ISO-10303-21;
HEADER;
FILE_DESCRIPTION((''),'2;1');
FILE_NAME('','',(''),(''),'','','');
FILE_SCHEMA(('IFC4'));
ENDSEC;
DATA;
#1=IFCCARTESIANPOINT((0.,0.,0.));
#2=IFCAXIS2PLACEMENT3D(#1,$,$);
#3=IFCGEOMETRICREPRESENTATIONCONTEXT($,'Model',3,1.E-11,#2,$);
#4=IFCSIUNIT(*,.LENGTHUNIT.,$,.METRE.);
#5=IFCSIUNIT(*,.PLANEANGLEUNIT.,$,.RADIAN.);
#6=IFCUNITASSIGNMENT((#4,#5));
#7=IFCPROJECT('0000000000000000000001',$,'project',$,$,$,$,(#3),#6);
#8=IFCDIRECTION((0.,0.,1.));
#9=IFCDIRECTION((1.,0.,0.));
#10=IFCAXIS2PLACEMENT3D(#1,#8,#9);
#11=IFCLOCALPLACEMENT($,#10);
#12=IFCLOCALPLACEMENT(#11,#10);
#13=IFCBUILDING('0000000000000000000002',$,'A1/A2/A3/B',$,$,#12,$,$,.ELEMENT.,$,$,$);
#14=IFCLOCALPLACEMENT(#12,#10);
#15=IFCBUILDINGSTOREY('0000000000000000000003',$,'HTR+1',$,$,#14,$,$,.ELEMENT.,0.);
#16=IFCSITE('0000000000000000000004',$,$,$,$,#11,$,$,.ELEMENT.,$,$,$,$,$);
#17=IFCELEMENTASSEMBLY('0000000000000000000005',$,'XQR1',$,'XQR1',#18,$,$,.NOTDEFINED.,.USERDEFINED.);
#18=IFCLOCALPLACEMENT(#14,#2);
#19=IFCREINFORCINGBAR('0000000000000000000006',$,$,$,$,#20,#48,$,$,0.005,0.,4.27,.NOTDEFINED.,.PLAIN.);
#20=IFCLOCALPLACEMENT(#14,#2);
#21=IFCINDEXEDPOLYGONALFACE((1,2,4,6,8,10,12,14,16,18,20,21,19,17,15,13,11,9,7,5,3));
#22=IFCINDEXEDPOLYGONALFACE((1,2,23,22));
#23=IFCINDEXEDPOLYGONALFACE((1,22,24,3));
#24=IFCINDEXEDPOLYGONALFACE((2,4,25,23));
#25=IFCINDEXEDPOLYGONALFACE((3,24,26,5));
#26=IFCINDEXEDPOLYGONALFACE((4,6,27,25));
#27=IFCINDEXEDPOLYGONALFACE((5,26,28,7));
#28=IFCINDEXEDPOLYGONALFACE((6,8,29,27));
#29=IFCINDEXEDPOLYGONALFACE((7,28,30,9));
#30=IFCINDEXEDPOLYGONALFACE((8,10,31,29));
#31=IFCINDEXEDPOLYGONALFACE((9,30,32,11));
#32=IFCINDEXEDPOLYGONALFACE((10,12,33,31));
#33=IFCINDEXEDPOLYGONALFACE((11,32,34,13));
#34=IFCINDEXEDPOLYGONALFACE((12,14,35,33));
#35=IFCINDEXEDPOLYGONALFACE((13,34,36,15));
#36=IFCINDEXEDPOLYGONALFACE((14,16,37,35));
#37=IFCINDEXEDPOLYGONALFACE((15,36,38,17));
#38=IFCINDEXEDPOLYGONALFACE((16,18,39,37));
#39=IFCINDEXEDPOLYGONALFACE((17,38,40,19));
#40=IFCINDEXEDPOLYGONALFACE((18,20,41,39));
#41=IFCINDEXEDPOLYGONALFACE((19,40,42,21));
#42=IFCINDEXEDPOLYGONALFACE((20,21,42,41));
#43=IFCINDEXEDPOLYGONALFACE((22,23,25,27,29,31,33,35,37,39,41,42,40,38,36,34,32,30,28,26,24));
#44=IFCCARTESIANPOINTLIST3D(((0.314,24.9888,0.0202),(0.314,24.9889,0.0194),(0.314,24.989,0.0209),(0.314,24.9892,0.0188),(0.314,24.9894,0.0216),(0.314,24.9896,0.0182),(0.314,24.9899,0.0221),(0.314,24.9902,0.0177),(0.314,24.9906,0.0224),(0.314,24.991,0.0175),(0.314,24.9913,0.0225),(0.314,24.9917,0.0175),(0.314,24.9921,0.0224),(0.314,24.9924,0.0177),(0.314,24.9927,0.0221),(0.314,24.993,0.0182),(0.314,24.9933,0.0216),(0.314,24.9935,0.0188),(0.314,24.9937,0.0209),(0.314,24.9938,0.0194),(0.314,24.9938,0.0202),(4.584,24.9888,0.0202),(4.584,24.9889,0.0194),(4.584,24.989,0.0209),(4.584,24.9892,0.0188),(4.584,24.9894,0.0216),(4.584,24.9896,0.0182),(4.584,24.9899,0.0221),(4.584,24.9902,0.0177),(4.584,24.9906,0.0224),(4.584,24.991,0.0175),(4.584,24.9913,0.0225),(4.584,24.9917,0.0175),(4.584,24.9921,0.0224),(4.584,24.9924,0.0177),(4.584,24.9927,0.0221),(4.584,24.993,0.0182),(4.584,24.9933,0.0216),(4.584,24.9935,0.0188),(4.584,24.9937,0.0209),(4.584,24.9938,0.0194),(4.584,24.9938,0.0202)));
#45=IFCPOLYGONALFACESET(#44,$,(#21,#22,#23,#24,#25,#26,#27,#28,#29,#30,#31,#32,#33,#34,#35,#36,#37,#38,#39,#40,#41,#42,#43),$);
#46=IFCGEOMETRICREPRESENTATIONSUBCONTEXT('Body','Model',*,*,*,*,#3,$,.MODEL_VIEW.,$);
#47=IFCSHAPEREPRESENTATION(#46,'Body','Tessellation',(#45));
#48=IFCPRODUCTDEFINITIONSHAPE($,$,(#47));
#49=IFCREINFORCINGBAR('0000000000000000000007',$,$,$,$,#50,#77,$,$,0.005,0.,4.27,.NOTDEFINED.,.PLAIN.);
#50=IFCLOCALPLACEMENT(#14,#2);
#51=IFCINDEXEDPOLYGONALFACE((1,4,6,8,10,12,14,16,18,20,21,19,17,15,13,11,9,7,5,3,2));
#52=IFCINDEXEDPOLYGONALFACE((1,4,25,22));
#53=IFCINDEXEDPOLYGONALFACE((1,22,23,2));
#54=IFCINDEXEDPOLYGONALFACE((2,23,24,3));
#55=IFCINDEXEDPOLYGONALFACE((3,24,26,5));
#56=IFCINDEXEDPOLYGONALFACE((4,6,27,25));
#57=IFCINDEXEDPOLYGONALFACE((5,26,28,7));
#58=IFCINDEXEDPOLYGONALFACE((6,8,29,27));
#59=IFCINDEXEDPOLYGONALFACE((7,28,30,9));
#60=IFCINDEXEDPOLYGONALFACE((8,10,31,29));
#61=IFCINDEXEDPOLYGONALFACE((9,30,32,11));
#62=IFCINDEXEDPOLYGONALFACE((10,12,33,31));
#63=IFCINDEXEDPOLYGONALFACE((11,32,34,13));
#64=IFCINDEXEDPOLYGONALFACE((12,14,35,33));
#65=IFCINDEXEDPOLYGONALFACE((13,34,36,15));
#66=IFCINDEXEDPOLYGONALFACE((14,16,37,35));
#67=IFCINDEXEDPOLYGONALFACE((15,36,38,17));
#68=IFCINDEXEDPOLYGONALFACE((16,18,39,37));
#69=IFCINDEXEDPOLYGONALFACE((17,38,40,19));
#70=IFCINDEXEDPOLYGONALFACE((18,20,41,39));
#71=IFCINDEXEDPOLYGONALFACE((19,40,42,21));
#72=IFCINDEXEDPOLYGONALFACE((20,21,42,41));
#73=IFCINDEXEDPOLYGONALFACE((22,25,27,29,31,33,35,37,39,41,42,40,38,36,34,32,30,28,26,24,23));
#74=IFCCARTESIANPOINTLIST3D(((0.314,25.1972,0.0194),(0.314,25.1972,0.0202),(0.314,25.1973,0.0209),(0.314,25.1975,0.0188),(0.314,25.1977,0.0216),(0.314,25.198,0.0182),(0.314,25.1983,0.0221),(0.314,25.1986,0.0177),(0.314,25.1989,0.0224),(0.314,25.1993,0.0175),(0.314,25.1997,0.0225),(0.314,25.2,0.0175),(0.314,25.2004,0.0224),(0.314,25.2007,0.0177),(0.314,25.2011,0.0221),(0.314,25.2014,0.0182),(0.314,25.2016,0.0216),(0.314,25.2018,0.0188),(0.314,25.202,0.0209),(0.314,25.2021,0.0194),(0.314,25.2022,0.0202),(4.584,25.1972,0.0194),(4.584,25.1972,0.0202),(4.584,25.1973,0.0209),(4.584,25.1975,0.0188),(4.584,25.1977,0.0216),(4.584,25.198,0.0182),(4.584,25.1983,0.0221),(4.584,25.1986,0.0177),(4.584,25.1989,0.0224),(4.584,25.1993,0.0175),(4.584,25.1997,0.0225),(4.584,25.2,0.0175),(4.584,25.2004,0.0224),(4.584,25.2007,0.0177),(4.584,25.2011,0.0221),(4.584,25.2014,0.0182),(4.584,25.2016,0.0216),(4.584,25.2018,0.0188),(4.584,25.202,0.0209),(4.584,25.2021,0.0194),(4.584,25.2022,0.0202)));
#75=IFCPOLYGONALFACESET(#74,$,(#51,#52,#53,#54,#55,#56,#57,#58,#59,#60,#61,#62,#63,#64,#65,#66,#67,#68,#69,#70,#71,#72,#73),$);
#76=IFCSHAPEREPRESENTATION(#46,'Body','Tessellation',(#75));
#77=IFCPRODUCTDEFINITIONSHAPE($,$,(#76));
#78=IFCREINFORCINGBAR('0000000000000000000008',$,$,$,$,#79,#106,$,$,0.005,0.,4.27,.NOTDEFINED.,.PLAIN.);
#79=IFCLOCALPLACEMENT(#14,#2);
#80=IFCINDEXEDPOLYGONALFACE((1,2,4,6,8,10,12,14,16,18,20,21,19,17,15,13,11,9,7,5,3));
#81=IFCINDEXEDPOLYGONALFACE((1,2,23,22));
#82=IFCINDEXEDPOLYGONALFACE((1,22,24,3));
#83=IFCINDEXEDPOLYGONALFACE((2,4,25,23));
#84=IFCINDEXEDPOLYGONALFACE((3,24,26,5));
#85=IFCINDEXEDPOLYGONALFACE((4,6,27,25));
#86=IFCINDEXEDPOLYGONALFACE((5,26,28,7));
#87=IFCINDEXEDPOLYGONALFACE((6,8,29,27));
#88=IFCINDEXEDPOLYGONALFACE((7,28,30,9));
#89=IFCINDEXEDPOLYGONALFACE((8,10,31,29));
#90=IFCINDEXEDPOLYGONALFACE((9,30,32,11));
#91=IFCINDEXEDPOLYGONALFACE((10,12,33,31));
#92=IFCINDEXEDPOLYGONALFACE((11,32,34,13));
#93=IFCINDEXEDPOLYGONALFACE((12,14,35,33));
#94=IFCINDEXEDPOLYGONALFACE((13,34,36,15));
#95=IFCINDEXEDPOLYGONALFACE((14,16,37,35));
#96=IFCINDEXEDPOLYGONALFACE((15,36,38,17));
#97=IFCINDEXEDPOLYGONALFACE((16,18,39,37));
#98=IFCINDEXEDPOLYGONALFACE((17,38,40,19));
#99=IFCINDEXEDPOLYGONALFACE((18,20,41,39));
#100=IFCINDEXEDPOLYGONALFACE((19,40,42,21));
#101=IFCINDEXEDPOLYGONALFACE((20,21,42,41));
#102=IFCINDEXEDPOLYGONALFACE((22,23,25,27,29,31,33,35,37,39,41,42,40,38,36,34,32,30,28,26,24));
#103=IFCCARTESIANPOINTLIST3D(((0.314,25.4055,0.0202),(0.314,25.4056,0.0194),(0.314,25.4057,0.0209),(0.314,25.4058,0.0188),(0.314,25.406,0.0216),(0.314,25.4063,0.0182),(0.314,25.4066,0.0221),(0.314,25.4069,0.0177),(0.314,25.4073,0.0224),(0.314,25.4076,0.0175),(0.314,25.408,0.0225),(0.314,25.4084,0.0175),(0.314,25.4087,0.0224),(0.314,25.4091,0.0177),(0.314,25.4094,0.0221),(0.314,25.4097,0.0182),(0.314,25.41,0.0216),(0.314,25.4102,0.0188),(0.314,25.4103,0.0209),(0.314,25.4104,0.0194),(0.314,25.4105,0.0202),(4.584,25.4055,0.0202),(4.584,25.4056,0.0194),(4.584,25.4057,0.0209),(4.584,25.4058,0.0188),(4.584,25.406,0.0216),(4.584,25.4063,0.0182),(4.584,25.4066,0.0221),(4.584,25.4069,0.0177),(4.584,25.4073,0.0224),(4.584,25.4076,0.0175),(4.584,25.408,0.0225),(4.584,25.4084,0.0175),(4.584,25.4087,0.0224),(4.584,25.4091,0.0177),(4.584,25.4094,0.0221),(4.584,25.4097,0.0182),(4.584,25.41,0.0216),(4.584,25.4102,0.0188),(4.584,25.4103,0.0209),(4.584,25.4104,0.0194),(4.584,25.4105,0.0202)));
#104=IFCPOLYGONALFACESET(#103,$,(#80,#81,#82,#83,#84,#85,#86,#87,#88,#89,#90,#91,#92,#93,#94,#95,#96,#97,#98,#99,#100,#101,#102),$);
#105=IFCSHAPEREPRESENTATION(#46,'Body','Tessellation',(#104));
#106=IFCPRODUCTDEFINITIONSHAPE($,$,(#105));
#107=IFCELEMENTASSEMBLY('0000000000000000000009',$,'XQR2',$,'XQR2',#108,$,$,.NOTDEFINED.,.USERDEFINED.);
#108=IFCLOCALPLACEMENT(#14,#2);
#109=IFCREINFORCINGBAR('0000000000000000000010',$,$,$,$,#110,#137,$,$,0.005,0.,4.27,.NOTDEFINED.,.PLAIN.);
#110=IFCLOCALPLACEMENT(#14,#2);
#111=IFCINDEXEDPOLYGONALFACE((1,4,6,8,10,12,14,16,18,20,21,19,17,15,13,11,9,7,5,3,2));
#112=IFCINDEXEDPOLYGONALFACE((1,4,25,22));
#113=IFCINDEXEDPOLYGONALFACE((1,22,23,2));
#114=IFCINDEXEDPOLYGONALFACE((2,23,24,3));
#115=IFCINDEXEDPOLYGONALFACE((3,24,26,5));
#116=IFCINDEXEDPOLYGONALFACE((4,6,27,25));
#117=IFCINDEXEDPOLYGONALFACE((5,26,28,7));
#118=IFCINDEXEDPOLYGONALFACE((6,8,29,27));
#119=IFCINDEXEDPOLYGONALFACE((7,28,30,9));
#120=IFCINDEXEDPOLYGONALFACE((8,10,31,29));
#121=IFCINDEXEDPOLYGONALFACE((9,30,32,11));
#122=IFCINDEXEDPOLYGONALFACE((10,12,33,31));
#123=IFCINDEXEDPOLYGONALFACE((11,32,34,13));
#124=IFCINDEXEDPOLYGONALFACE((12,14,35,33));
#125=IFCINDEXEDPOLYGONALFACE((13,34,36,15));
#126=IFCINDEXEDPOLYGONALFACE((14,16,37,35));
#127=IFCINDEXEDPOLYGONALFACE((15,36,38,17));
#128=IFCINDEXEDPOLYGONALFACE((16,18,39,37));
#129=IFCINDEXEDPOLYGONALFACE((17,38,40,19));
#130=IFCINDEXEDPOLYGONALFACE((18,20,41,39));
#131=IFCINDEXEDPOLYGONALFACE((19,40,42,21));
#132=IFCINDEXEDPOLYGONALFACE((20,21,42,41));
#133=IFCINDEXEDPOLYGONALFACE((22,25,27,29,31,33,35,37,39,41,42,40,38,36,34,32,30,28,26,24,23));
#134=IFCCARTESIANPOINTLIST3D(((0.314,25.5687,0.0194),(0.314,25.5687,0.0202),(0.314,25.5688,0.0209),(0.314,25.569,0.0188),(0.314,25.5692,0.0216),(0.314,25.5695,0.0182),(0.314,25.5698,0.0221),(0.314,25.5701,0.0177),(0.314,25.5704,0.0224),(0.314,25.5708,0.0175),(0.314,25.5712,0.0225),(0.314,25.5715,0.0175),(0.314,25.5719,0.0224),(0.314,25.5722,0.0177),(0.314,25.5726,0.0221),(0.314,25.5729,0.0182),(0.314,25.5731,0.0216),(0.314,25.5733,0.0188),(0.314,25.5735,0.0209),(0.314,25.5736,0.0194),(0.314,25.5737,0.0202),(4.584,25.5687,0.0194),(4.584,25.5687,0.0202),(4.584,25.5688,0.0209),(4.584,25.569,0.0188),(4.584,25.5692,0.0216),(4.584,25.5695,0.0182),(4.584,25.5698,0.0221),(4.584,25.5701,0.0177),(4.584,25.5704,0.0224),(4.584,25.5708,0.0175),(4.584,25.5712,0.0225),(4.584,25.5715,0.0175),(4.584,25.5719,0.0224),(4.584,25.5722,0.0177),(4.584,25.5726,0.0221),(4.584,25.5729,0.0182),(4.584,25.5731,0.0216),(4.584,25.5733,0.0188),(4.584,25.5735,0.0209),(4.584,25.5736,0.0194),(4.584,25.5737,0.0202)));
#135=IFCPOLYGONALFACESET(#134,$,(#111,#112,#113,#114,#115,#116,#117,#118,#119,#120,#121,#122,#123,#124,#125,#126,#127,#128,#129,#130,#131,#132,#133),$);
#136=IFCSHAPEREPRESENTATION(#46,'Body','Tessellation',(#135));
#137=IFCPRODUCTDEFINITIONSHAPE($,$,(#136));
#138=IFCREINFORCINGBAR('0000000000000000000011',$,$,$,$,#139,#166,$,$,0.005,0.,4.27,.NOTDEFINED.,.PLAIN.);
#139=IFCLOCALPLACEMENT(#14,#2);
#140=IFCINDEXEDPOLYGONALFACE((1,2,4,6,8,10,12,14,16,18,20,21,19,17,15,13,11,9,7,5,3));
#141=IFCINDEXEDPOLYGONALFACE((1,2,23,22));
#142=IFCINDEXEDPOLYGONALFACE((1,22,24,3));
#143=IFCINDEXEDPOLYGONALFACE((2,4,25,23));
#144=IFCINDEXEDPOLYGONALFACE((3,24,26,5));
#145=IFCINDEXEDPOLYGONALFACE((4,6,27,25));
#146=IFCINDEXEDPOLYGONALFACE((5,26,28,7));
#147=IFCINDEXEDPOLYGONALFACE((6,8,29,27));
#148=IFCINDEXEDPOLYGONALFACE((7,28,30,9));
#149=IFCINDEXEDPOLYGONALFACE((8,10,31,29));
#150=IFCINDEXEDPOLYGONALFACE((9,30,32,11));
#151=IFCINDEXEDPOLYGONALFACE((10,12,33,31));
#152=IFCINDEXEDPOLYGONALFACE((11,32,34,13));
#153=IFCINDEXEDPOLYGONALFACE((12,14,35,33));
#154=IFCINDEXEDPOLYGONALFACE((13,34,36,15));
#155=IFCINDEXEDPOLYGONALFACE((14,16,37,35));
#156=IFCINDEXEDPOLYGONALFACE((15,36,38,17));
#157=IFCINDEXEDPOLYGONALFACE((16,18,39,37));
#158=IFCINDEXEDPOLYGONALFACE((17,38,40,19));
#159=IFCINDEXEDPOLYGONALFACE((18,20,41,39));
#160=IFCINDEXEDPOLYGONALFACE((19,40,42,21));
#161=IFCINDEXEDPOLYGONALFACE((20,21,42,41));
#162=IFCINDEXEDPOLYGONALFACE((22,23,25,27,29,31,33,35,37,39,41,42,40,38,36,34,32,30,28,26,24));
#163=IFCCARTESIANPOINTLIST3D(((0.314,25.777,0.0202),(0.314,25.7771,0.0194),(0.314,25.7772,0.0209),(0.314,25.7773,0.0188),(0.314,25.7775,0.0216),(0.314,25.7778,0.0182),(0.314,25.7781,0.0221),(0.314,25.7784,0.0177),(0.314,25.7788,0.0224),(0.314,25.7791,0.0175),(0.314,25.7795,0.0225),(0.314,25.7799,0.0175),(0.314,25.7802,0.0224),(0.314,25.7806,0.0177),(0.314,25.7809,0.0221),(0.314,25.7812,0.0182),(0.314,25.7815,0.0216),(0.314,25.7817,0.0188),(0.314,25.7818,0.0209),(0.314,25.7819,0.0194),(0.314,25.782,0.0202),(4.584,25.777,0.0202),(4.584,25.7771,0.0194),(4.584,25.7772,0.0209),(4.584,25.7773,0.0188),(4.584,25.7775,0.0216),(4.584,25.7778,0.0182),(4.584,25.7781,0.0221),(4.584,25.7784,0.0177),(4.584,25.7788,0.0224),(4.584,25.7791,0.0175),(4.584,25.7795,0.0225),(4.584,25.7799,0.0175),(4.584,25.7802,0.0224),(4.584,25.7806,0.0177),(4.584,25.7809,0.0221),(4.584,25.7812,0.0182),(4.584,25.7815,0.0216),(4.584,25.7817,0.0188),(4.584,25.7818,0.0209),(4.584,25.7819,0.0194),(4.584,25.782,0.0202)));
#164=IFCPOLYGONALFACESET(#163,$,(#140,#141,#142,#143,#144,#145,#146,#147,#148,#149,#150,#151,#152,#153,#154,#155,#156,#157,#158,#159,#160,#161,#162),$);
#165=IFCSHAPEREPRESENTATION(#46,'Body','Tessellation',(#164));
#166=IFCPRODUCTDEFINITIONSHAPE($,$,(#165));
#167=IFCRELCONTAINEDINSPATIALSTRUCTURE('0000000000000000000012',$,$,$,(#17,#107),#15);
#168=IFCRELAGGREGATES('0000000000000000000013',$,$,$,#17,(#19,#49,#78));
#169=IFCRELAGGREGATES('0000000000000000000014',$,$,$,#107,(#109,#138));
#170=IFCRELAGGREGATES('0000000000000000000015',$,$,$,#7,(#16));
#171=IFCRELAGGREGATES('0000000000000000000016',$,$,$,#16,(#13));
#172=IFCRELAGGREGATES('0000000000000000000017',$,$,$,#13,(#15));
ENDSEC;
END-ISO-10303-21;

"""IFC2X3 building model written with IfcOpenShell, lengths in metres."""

from ifc_helpers import new_model, entity, si_unit, origin, origin_with_axes, place, context, subcontext, project, spatial, shape, element, aggregate, save


model = new_model("IFC2X3")

# Units and contexts
model_context = context("Model", 3, precision=1e-11, world=origin())
body_context = subcontext(model_context, "Body", "Model", "MODEL_VIEW")
ifc_project = project(units=[si_unit("LENGTHUNIT", "METRE"), si_unit("PLANEANGLEUNIT", "RADIAN")], contexts=[model_context])

# Site, building, storey
site_placement = place(None, origin_with_axes())
site = spatial("IfcSite", under=ifc_project, at=site_placement, CompositionType="ELEMENT")
building_placement = place(site_placement, origin_with_axes())
building = spatial("IfcBuilding", under=site, at=building_placement, Name="A1/A2/A3/B", CompositionType="ELEMENT")
storey_placement = place(building_placement, origin_with_axes())
storey = spatial("IfcBuildingStorey", under=building, at=storey_placement, Name="HTR+1", CompositionType="ELEMENT", Elevation=0.0)

# Element assemblies, reinforcing bars
assembly_1_placement = place(storey_placement, origin_with_axes())
assembly_1 = element("IfcElementAssembly", 1, at=assembly_1_placement, inside=storey, Name="XQR1", ObjectType="XQR1", AssemblyPlace="NOTDEFINED", PredefinedType="USERDEFINED")
reinforcing_bar_1_placement = place(assembly_1_placement, origin_with_axes())
reinforcing_bar_1 = element("IfcReinforcingBar", 2, at=reinforcing_bar_1_placement, BarLength=4.27, BarRole="NOTDEFINED", BarSurface="PLAIN", CrossSectionArea=0.0, NominalDiameter=0.005, shapes=[
    shape(body_context, "Body", "AdvancedSweptSolid", [entity("IfcSweptDiskSolid", entity("IfcPolyline", [entity("IfcCartesianPoint", [0.314, 24.9913, 0.02]), entity("IfcCartesianPoint", [4.584, 24.9913, 0.02])]), 0.0025, None, 0.0, 4.27)]),
    shape(body_context, "Body", "AdvancedSweptSolid", [entity("IfcSweptDiskSolid", entity("IfcPolyline", [entity("IfcCartesianPoint", [0.314, 24.9913, 0.02]), entity("IfcCartesianPoint", [4.584, 24.9913, 0.02])]), 0.0025, None, 0.0, 4.27)]),
])
reinforcing_bar_2_placement = place(assembly_1_placement, origin_with_axes())
reinforcing_bar_2 = element("IfcReinforcingBar", 3, at=reinforcing_bar_2_placement, BarLength=4.27, BarRole="NOTDEFINED", BarSurface="PLAIN", CrossSectionArea=0.0, NominalDiameter=0.005, shapes=[
    shape(body_context, "Body", "AdvancedSweptSolid", [entity("IfcSweptDiskSolid", entity("IfcPolyline", [entity("IfcCartesianPoint", [0.314, 25.1997, 0.02]), entity("IfcCartesianPoint", [4.584, 25.1997, 0.02])]), 0.0025, None, 0.0, 4.27)]),
    shape(body_context, "Body", "AdvancedSweptSolid", [entity("IfcSweptDiskSolid", entity("IfcPolyline", [entity("IfcCartesianPoint", [0.314, 25.1997, 0.02]), entity("IfcCartesianPoint", [4.584, 25.1997, 0.02])]), 0.0025, None, 0.0, 4.27)]),
])
reinforcing_bar_3_placement = place(assembly_1_placement, origin_with_axes())
reinforcing_bar_3 = element("IfcReinforcingBar", 4, at=reinforcing_bar_3_placement, BarLength=4.27, BarRole="NOTDEFINED", BarSurface="PLAIN", CrossSectionArea=0.0, NominalDiameter=0.005, shapes=[
    shape(body_context, "Body", "AdvancedSweptSolid", [entity("IfcSweptDiskSolid", entity("IfcPolyline", [entity("IfcCartesianPoint", [0.314, 25.408, 0.02]), entity("IfcCartesianPoint", [4.584, 25.408, 0.02])]), 0.0025, None, 0.0, 4.27)]),
    shape(body_context, "Body", "AdvancedSweptSolid", [entity("IfcSweptDiskSolid", entity("IfcPolyline", [entity("IfcCartesianPoint", [0.314, 25.408, 0.02]), entity("IfcCartesianPoint", [4.584, 25.408, 0.02])]), 0.0025, None, 0.0, 4.27)]),
])
aggregate(assembly_1, [reinforcing_bar_1, reinforcing_bar_2, reinforcing_bar_3])
assembly_2_placement = place(storey_placement, origin_with_axes())
assembly_2 = element("IfcElementAssembly", 5, at=assembly_2_placement, inside=storey, Name="XQR2", ObjectType="XQR2", AssemblyPlace="NOTDEFINED", PredefinedType="USERDEFINED")
reinforcing_bar_4_placement = place(assembly_2_placement, origin_with_axes())
reinforcing_bar_4 = element("IfcReinforcingBar", 6, at=reinforcing_bar_4_placement, BarLength=4.27, BarRole="NOTDEFINED", BarSurface="PLAIN", CrossSectionArea=0.0, NominalDiameter=0.005, shapes=[
    shape(body_context, "Body", "AdvancedSweptSolid", [entity("IfcSweptDiskSolid", entity("IfcPolyline", [entity("IfcCartesianPoint", [0.314, 25.5712, 0.02]), entity("IfcCartesianPoint", [4.584, 25.5712, 0.02])]), 0.0025, None, 0.0, 4.27)]),
    shape(body_context, "Body", "AdvancedSweptSolid", [entity("IfcSweptDiskSolid", entity("IfcPolyline", [entity("IfcCartesianPoint", [0.314, 25.5712, 0.02]), entity("IfcCartesianPoint", [4.584, 25.5712, 0.02])]), 0.0025, None, 0.0, 4.27)]),
])
reinforcing_bar_5_placement = place(assembly_2_placement, origin_with_axes())
reinforcing_bar_5 = element("IfcReinforcingBar", 7, at=reinforcing_bar_5_placement, BarLength=4.27, BarRole="NOTDEFINED", BarSurface="PLAIN", CrossSectionArea=0.0, NominalDiameter=0.005, shapes=[
    shape(body_context, "Body", "AdvancedSweptSolid", [entity("IfcSweptDiskSolid", entity("IfcPolyline", [entity("IfcCartesianPoint", [0.314, 25.7795, 0.02]), entity("IfcCartesianPoint", [4.584, 25.7795, 0.02])]), 0.0025, None, 0.0, 4.27)]),
    shape(body_context, "Body", "AdvancedSweptSolid", [entity("IfcSweptDiskSolid", entity("IfcPolyline", [entity("IfcCartesianPoint", [0.314, 25.7795, 0.02]), entity("IfcCartesianPoint", [4.584, 25.7795, 0.02])]), 0.0025, None, 0.0, 4.27)]),
])
aggregate(assembly_2, [reinforcing_bar_4, reinforcing_bar_5])

save(model, "model.ifc")
